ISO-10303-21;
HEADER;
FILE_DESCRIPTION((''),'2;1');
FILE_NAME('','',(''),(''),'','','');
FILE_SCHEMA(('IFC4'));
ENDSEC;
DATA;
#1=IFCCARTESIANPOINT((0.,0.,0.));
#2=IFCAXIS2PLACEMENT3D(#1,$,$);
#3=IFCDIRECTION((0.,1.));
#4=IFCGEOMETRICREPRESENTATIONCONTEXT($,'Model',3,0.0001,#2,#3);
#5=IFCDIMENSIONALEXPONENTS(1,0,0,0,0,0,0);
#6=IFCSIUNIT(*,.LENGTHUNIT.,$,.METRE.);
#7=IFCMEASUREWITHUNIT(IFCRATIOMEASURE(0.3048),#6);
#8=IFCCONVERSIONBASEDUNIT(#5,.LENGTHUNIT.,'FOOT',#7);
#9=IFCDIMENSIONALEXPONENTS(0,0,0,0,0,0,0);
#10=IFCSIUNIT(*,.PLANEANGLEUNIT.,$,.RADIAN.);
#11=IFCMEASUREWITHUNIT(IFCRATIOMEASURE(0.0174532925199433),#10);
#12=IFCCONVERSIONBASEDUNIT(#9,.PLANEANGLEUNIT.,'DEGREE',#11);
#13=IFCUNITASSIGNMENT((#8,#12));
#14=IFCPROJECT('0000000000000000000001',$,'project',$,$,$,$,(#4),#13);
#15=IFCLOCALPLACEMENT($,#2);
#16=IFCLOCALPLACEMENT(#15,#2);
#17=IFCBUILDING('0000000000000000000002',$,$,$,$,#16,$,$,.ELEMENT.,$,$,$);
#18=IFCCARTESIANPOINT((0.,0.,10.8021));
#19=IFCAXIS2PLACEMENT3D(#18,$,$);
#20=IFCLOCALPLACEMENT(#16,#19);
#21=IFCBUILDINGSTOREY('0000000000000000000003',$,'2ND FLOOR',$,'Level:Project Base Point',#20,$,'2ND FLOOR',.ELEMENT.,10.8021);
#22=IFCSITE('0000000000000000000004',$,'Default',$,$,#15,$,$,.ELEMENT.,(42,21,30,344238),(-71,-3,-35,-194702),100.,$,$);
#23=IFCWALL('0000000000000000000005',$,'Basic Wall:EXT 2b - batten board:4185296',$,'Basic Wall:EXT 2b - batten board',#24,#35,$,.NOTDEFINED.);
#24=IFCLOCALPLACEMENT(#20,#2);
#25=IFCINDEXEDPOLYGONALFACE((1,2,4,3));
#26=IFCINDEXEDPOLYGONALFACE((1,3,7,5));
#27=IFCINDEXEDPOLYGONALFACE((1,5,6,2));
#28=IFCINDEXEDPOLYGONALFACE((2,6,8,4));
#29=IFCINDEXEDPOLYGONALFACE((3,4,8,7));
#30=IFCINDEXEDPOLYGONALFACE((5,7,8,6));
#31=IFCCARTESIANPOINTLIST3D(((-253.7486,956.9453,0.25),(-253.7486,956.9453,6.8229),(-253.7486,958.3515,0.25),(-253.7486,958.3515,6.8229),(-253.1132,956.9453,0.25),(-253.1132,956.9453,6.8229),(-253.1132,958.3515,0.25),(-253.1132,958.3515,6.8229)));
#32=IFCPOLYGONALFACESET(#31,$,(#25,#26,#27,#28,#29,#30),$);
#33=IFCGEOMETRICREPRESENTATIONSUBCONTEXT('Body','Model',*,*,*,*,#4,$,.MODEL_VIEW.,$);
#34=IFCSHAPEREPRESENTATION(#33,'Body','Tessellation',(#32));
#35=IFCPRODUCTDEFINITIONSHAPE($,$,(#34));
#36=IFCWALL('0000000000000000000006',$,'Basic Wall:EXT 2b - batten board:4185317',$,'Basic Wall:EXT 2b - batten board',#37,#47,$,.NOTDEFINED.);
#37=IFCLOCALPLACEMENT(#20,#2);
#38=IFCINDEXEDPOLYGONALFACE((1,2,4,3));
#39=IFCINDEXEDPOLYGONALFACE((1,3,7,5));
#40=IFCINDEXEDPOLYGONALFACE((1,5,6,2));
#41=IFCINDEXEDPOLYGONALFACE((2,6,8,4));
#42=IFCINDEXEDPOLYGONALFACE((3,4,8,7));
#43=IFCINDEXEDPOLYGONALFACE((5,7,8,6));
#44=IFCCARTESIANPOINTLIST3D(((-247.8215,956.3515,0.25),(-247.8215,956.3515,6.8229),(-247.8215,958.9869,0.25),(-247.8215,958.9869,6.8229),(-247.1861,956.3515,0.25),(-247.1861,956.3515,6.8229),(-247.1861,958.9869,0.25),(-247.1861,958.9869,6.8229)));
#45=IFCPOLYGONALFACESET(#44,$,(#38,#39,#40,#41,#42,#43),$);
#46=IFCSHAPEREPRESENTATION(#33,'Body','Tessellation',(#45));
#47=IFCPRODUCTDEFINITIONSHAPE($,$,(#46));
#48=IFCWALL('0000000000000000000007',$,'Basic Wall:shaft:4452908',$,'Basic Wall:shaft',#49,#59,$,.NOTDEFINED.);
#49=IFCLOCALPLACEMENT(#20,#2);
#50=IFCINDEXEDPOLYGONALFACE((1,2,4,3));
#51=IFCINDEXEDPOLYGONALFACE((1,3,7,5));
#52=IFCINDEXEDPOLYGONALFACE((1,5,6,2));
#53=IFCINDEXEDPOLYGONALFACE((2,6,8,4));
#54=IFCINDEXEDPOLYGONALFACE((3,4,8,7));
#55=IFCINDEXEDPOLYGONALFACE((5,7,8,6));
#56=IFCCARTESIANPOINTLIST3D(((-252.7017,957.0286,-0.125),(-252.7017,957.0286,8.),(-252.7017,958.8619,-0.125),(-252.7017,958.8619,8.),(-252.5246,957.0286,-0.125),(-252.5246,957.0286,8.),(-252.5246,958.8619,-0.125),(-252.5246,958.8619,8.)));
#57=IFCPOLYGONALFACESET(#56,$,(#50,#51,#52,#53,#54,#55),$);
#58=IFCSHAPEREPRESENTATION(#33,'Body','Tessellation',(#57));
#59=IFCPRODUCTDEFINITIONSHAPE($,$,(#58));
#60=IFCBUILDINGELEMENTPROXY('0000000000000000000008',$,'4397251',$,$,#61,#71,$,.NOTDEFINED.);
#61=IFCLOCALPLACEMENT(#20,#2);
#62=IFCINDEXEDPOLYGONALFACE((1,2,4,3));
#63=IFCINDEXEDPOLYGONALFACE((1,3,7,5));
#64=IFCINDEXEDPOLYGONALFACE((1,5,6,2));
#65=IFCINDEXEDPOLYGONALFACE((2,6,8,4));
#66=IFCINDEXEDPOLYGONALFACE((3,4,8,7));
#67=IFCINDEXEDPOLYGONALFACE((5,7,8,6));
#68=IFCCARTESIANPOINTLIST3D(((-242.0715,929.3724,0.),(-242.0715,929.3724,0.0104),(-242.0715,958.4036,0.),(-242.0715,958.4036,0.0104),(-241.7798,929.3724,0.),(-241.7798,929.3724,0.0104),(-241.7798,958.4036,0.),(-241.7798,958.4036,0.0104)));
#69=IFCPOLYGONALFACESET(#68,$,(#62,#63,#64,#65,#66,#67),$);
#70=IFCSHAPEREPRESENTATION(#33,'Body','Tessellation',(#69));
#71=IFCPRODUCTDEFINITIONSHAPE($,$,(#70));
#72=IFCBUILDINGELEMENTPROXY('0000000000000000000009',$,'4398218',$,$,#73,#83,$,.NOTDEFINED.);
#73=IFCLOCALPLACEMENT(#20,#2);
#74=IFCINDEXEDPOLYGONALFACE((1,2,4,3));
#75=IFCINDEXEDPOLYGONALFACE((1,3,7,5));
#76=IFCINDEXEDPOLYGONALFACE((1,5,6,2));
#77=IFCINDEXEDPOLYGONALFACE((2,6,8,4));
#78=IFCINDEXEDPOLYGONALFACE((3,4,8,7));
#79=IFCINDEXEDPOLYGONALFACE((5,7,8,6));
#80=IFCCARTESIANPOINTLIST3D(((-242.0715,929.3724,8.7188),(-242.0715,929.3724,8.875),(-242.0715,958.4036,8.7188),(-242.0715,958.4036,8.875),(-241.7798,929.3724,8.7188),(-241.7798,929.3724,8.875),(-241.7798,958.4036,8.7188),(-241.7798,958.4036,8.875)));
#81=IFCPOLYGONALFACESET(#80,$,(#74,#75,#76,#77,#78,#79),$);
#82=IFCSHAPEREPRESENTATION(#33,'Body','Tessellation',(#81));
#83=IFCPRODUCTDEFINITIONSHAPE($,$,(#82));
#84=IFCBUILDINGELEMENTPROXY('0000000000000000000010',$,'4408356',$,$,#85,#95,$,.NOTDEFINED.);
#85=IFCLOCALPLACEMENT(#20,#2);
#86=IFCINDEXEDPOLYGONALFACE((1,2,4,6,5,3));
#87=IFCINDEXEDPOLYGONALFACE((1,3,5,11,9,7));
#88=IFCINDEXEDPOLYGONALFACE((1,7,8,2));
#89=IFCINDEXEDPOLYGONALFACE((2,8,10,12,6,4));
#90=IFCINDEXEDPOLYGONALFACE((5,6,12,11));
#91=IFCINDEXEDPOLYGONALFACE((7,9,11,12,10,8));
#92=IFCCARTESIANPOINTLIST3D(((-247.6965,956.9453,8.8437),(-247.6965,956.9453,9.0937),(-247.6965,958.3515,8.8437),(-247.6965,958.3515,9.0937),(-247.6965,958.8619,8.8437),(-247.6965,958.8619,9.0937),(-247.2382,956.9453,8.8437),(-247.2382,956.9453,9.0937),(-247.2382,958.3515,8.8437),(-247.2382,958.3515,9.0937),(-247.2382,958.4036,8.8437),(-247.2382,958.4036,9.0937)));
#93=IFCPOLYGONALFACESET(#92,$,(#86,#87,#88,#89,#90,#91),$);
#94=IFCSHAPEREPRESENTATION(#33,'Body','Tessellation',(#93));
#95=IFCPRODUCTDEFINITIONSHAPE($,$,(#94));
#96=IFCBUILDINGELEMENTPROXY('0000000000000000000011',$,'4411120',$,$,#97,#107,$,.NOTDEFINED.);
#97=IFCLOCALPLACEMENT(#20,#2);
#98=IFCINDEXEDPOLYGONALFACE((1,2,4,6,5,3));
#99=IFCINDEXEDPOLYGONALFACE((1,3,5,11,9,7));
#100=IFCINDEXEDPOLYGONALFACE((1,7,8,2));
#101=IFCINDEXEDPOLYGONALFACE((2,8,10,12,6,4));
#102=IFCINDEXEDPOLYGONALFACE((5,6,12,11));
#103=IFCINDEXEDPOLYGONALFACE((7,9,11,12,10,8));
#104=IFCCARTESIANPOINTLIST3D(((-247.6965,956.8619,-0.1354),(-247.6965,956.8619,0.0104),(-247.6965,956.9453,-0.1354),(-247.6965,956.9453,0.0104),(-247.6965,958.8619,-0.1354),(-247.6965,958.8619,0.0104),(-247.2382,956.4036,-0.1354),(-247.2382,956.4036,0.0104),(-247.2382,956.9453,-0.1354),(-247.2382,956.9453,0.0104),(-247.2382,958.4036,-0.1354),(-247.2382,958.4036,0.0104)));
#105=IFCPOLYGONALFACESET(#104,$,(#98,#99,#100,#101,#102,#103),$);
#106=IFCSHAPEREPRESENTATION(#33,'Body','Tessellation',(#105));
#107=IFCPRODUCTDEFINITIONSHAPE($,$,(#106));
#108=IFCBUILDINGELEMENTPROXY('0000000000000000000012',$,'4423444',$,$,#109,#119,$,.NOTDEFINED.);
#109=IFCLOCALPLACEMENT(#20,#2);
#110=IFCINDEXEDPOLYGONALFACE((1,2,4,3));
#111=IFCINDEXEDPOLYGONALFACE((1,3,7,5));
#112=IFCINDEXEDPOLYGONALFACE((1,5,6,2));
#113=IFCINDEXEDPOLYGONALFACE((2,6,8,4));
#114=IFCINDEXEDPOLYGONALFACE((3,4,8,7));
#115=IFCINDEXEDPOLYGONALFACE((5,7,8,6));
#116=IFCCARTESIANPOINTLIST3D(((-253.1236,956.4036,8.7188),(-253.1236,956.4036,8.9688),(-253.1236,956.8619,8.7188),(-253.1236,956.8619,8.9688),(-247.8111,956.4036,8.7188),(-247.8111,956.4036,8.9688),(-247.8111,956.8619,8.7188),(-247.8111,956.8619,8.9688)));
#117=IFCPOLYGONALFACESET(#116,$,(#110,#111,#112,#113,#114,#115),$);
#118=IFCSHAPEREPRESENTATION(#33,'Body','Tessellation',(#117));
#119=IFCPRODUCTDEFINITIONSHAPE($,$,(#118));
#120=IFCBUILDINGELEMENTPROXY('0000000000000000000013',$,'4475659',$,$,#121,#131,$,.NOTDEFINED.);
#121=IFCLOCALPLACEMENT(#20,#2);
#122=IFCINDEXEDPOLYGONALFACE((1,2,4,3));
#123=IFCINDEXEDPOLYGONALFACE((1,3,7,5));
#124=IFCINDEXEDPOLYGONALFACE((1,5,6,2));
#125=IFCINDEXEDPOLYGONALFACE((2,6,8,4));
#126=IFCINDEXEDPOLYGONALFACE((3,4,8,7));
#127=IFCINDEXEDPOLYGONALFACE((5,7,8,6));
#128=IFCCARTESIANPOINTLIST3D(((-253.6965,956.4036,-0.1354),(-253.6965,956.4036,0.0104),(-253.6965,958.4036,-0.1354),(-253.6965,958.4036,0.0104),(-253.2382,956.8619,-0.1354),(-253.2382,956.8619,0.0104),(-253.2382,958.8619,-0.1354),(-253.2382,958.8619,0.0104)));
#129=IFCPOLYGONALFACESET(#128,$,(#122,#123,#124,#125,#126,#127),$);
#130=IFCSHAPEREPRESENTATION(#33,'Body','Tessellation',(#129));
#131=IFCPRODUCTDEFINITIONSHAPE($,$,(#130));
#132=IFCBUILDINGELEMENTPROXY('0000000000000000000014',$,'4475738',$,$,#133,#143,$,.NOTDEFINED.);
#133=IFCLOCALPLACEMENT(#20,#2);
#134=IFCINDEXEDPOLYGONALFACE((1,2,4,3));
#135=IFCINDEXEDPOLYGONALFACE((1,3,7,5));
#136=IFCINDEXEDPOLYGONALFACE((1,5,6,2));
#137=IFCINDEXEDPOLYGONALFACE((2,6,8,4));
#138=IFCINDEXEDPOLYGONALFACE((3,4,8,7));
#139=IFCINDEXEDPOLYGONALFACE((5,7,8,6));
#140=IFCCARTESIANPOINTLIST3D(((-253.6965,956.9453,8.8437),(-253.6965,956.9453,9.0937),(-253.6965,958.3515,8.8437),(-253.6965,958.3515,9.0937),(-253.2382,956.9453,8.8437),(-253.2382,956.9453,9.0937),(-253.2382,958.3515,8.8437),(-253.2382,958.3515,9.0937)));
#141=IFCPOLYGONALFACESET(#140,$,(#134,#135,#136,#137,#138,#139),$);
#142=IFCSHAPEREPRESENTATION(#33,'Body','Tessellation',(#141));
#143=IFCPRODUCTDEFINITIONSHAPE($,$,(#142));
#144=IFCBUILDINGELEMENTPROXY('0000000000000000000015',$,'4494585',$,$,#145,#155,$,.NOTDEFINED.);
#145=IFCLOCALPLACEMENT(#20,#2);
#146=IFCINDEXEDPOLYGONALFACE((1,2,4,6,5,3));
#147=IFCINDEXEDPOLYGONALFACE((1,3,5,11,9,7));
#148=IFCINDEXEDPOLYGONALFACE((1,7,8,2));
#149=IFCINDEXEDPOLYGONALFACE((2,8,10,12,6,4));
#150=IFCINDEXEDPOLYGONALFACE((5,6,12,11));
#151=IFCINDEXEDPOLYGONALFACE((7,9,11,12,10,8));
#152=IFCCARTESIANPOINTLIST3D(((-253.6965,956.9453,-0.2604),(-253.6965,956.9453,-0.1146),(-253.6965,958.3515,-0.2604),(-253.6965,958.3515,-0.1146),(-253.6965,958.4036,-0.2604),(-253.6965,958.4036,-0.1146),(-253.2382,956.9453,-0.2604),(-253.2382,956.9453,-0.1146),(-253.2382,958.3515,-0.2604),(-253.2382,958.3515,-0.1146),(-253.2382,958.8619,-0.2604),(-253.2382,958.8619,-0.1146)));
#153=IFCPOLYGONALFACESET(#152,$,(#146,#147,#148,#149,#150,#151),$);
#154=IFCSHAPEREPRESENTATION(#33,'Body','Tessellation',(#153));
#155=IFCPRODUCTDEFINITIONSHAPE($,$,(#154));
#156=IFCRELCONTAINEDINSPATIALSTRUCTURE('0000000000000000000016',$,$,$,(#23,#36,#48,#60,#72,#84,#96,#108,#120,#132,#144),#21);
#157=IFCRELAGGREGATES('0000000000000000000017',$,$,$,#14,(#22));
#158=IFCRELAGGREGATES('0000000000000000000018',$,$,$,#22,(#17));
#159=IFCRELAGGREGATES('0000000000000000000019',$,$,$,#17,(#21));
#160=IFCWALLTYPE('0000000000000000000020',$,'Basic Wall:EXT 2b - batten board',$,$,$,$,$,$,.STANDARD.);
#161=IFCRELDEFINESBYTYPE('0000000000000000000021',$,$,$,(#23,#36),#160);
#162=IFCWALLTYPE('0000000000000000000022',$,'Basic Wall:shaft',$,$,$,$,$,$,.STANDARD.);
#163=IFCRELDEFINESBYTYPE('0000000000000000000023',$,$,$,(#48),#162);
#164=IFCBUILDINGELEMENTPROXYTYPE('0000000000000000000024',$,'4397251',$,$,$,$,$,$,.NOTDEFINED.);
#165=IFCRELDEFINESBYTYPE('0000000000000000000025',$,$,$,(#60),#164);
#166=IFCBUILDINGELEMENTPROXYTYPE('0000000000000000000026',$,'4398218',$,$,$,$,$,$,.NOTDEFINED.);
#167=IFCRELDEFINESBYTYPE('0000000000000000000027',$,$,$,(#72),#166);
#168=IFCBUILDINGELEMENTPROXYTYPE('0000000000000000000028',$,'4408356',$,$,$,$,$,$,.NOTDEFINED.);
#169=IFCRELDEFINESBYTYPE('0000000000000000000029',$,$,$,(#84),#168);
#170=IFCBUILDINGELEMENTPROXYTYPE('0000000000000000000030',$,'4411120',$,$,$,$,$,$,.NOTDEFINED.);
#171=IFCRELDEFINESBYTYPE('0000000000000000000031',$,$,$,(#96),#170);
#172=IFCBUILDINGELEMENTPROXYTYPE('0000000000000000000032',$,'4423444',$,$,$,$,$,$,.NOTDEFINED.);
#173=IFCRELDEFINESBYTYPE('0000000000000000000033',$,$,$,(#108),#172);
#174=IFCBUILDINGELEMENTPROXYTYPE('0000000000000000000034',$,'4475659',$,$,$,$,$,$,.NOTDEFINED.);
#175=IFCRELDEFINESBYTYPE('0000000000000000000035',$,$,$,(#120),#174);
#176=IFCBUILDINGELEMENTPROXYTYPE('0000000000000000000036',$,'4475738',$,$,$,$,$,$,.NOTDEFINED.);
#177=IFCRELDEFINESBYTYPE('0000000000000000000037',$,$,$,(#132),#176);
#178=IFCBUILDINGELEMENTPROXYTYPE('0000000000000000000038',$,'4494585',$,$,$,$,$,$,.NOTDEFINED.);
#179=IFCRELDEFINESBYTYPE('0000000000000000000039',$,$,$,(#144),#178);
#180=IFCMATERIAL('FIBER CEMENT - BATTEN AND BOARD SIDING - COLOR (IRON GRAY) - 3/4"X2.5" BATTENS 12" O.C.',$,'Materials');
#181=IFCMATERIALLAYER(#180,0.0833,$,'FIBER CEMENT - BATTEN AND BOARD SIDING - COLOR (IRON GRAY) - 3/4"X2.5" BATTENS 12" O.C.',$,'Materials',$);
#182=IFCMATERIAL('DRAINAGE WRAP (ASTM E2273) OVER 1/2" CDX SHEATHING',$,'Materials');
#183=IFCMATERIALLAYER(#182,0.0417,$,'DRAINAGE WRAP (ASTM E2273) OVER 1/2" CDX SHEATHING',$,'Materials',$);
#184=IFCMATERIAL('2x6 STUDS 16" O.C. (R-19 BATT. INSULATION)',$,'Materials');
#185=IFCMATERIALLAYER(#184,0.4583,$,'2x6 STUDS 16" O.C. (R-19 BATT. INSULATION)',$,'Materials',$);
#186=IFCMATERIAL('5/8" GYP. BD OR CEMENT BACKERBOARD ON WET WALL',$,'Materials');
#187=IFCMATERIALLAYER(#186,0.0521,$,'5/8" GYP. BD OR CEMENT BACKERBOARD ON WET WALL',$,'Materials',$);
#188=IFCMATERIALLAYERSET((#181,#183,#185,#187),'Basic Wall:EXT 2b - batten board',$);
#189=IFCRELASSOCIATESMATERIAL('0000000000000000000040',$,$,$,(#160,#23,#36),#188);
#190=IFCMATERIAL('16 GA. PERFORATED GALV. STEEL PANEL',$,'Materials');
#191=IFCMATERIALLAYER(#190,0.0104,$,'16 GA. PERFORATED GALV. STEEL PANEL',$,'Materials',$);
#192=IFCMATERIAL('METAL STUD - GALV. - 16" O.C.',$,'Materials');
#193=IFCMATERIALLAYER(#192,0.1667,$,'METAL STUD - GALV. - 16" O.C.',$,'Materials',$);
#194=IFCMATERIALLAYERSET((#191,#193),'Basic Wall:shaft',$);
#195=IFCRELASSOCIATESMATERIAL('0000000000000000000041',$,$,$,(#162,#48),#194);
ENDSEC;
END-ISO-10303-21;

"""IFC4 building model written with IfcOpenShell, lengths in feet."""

from ifc_helpers import new_model, entity, si_unit, converted_unit, direction, frame, frame_2d, origin, origin_2d_with_axis, place, context, subcontext, project, spatial, polyline, rectangle, outline, extrude, material, layer, layer_set, layer_usage, type_object, element, save


model = new_model("IFC4")

# Units and contexts
model_context = context("Model", 3, precision=0.0001, world=origin(), true_north=direction((0.0, 1.0)))
body_context = subcontext(model_context, "Body", "Model", "MODEL_VIEW")
ifc_project = project(units=[converted_unit("LENGTHUNIT", "FOOT", entity("IfcRatioMeasure", 0.3048), si_unit("LENGTHUNIT", "METRE"), dimensions=[1, 0, 0, 0, 0, 0, 0]), converted_unit("PLANEANGLEUNIT", "DEGREE", entity("IfcRatioMeasure", 0.0174532925199433), si_unit("PLANEANGLEUNIT", "RADIAN"), dimensions=[0, 0, 0, 0, 0, 0, 0])], contexts=[model_context])

# Site, building, storey
site_placement = place(None, origin())
site = spatial("IfcSite", under=ifc_project, at=site_placement, Name="Default", CompositionType="ELEMENT", RefLatitude=(42, 21, 30, 344238), RefLongitude=(-71, -3, -35, -194702), RefElevation=100.0)
building_placement = place(site_placement, origin())
building = spatial("IfcBuilding", under=site, at=building_placement, CompositionType="ELEMENT")
storey_placement = place(building_placement, frame((0.0, 0.0, 10.8021)))
storey = spatial("IfcBuildingStorey", under=building, at=storey_placement, Name="2ND FLOOR", ObjectType="Level:Project Base Point", LongName="2ND FLOOR", CompositionType="ELEMENT", Elevation=10.8021)

# Walls
ifc_material_1 = material(Name="DRAINAGE WRAP (ASTM E2273) OVER 1/2\" CDX SHEATHING", Category="Materials")
ifc_material_2 = material(Name="2x6 STUDS 16\" O.C. (R-19 BATT. INSULATION)", Category="Materials")
ifc_material_3 = material(Name="5/8\" GYP. BD OR CEMENT BACKERBOARD ON WET WALL", Category="Materials")
ifc_material_4 = material(Name="FIBER CEMENT - BATTEN AND BOARD SIDING - COLOR (IRON GRAY) - 3/4\"X2.5\" BATTENS 12\" O.C.", Category="Materials")
ifc_layer_1 = layer(ifc_material_4, 0.0833, Name="FIBER CEMENT - BATTEN AND BOARD SIDING - COLOR (IRON GRAY) - 3/4\"X2.5\" BATTENS 12\" O.C.", Category="Materials")
ifc_layer_2 = layer(ifc_material_1, 0.0417, Name="DRAINAGE WRAP (ASTM E2273) OVER 1/2\" CDX SHEATHING", Category="Materials")
ifc_layer_3 = layer(ifc_material_2, 0.4583, Name="2x6 STUDS 16\" O.C. (R-19 BATT. INSULATION)", Category="Materials")
ifc_layer_4 = layer(ifc_material_3, 0.0521, Name="5/8\" GYP. BD OR CEMENT BACKERBOARD ON WET WALL", Category="Materials")
ifc_layer_set_1 = layer_set([ifc_layer_1, ifc_layer_2, ifc_layer_3, ifc_layer_4], Name="Basic Wall:EXT 2b - batten board")
ifc_layer_usage_1 = layer_usage(ifc_layer_set_1, "AXIS2", "POSITIVE", -0.3177)
wall_type_1 = type_object("IfcWallType", Name="Basic Wall:EXT 2b - batten board", PredefinedType="STANDARD", material=ifc_layer_set_1)
wall_1_placement = place(storey_placement, frame((-253.4309, 956.9453, 0.25), z_axis=(0.0, 0.0, 1.0), x_axis=(0.0, 1.0, 0.0)))
element("IfcWall", 1, at=wall_1_placement, inside=storey, type_object=wall_type_1, material=ifc_layer_usage_1, Name="Basic Wall:EXT 2b - batten board:4185296", ObjectType="Basic Wall:EXT 2b - batten board", PredefinedType="NOTDEFINED", context=body_context, shape_type="SweptSolid", body=[
    extrude(rectangle(XDim=1.4062, YDim=0.6354, at=frame_2d((0.7031, 0.0), x_axis=(-1.0, 0.0))), origin(), (0.0, 0.0, 1.0), 6.5729),
])
ifc_layer_usage_2 = layer_usage(ifc_layer_set_1, "AXIS2", "NEGATIVE", 0.3177)
wall_2_placement = place(storey_placement, frame((-247.5038, 956.3515, 0.25), z_axis=(0.0, 0.0, 1.0), x_axis=(0.0, 1.0, 0.0)))
element("IfcWall", 2, at=wall_2_placement, inside=storey, type_object=wall_type_1, material=ifc_layer_usage_2, Name="Basic Wall:EXT 2b - batten board:4185317", ObjectType="Basic Wall:EXT 2b - batten board", PredefinedType="NOTDEFINED", context=body_context, shape_type="SweptSolid", body=[
    extrude(rectangle(XDim=2.6354, YDim=0.6354, at=frame_2d((1.3177, 0.0), x_axis=(-1.0, 0.0))), origin(), (0.0, 0.0, 1.0), 6.5729),
])
ifc_material_5 = material(Name="16 GA. PERFORATED GALV. STEEL PANEL", Category="Materials")
ifc_layer_5 = layer(ifc_material_5, 0.0104, Name="16 GA. PERFORATED GALV. STEEL PANEL", Category="Materials")
ifc_material_6 = material(Name="METAL STUD - GALV. - 16\" O.C.", Category="Materials")
ifc_layer_6 = layer(ifc_material_6, 0.1667, Name="METAL STUD - GALV. - 16\" O.C.", Category="Materials")
ifc_layer_set_2 = layer_set([ifc_layer_5, ifc_layer_6], Name="Basic Wall:shaft")
ifc_layer_usage_3 = layer_usage(ifc_layer_set_2, "AXIS2", "POSITIVE", -0.0885)
wall_type_2 = type_object("IfcWallType", Name="Basic Wall:shaft", PredefinedType="STANDARD", material=ifc_layer_set_2)
wall_3_placement = place(storey_placement, frame((-252.6132, 957.0286, -0.125), z_axis=(0.0, 0.0, 1.0), x_axis=(0.0, 1.0, 0.0)))
element("IfcWall", 3, at=wall_3_placement, inside=storey, type_object=wall_type_2, material=ifc_layer_usage_3, Name="Basic Wall:shaft:4452908", ObjectType="Basic Wall:shaft", PredefinedType="NOTDEFINED", context=body_context, shape_type="SweptSolid", body=[
    extrude(rectangle(XDim=1.8333, YDim=0.1771, at=frame_2d((0.9167, 0.0), x_axis=(-1.0, 0.0))), origin(), (0.0, 0.0, 1.0), 8.125),
])

# Building element proxies
building_element_proxy_type_1 = type_object("IfcBuildingElementProxyType", Name="4397251", PredefinedType="NOTDEFINED")
proxy_1_placement = place(storey_placement, frame((-242.0715, 929.3724, 0.0)))
element("IfcBuildingElementProxy", 4, at=proxy_1_placement, inside=storey, type_object=building_element_proxy_type_1, Name="4397251", PredefinedType="NOTDEFINED", context=body_context, shape_type="SweptSolid", body=[
    extrude(rectangle(XDim=29.0313, YDim=0.2917, at=origin_2d_with_axis()), frame((0.1458, 14.5156, 0.0), z_axis=(0.0, 0.0, 1.0), x_axis=(0.0, 1.0, 0.0)), (0.0, 0.0, 1.0), 0.0104),
])
building_element_proxy_type_2 = type_object("IfcBuildingElementProxyType", Name="4398218", PredefinedType="NOTDEFINED")
proxy_2_placement = place(storey_placement, frame((-242.0715, 929.3724, 8.7188)))
element("IfcBuildingElementProxy", 5, at=proxy_2_placement, inside=storey, type_object=building_element_proxy_type_2, Name="4398218", PredefinedType="NOTDEFINED", context=body_context, shape_type="SweptSolid", body=[
    extrude(rectangle(XDim=29.0313, YDim=0.2917, at=origin_2d_with_axis()), frame((0.1458, 14.5156, 0.0), z_axis=(0.0, 0.0, 1.0), x_axis=(0.0, 1.0, 0.0)), (0.0, 0.0, 1.0), 0.1562),
])
building_element_proxy_type_3 = type_object("IfcBuildingElementProxyType", Name="4408356", PredefinedType="NOTDEFINED")
proxy_3_placement = place(storey_placement, frame((-247.6965, 956.9453, 8.8437)))
element("IfcBuildingElementProxy", 6, at=proxy_3_placement, inside=storey, type_object=building_element_proxy_type_3, Name="4408356", PredefinedType="NOTDEFINED", context=body_context, shape_type="SweptSolid", body=[
    extrude(outline(polyline([(-1.0313, -0.2292), (0.375, -0.2292), (0.4271, -0.2292), (0.8854, 0.2292), (0.375, 0.2292), (-1.0313, 0.2292), (-1.0313, -0.2292)])), frame((0.2292, 1.0313, 0.0), z_axis=(0.0, 0.0, 1.0), x_axis=(0.0, 1.0, 0.0)), (0.0, 0.0, 1.0), 0.25),
])
building_element_proxy_type_4 = type_object("IfcBuildingElementProxyType", Name="4411120", PredefinedType="NOTDEFINED")
proxy_4_placement = place(storey_placement, frame((-247.6965, 956.4036, -0.1354)))
element("IfcBuildingElementProxy", 7, at=proxy_4_placement, inside=storey, type_object=building_element_proxy_type_4, Name="4411120", PredefinedType="NOTDEFINED", context=body_context, shape_type="SweptSolid", body=[
    extrude(outline(polyline([(-1.0, -0.2292), (-0.4583, -0.2292), (1.0, -0.2292), (1.4583, 0.2292), (-0.4583, 0.2292), (-0.5417, 0.2292), (-1.0, -0.2292)])), frame((0.2292, 1.0, 0.0), z_axis=(0.0, 0.0, 1.0), x_axis=(0.0, 1.0, 0.0)), (0.0, 0.0, 1.0), 0.1458),
])
building_element_proxy_type_5 = type_object("IfcBuildingElementProxyType", Name="4423444", PredefinedType="NOTDEFINED")
proxy_5_placement = place(storey_placement, frame((-253.1236, 956.4036, 8.7188)))
element("IfcBuildingElementProxy", 8, at=proxy_5_placement, inside=storey, type_object=building_element_proxy_type_5, Name="4423444", PredefinedType="NOTDEFINED", context=body_context, shape_type="SweptSolid", body=[
    extrude(rectangle(XDim=5.3125, YDim=0.4583, at=frame_2d((0.0, 0.0), x_axis=(1.0, 0.0))), frame((2.6563, 0.2292, 0.0)), (0.0, 0.0, 1.0), 0.25),
])
building_element_proxy_type_6 = type_object("IfcBuildingElementProxyType", Name="4475659", PredefinedType="NOTDEFINED")
proxy_6_placement = place(storey_placement, frame((-253.6965, 956.4036, -0.1354)))
element("IfcBuildingElementProxy", 9, at=proxy_6_placement, inside=storey, type_object=building_element_proxy_type_6, Name="4475659", PredefinedType="NOTDEFINED", context=body_context, shape_type="SweptSolid", body=[
    extrude(outline(polyline([(-0.7708, -0.2292), (1.2292, -0.2292), (0.7708, 0.2292), (-1.2292, 0.2292), (-0.7708, -0.2292)])), frame((0.2292, 1.2292, 0.0), z_axis=(0.0, 0.0, 1.0), x_axis=(0.0, 1.0, 0.0)), (0.0, 0.0, 1.0), 0.1458),
])
building_element_proxy_type_7 = type_object("IfcBuildingElementProxyType", Name="4475738", PredefinedType="NOTDEFINED")
proxy_7_placement = place(storey_placement, frame((-253.6965, 956.9453, 8.8437)))
element("IfcBuildingElementProxy", 10, at=proxy_7_placement, inside=storey, type_object=building_element_proxy_type_7, Name="4475738", PredefinedType="NOTDEFINED", context=body_context, shape_type="SweptSolid", body=[
    extrude(rectangle(XDim=1.4062, YDim=0.4583, at=frame_2d((0.0, 0.0), x_axis=(1.0, 0.0))), frame((0.2292, 0.7031, 0.0), z_axis=(0.0, 0.0, 1.0), x_axis=(0.0, 1.0, 0.0)), (0.0, 0.0, 1.0), 0.25),
])
building_element_proxy_type_8 = type_object("IfcBuildingElementProxyType", Name="4494585", PredefinedType="NOTDEFINED")
proxy_8_placement = place(storey_placement, frame((-253.6965, 956.9453, -0.2604)))
element("IfcBuildingElementProxy", 11, at=proxy_8_placement, inside=storey, type_object=building_element_proxy_type_8, Name="4494585", PredefinedType="NOTDEFINED", context=body_context, shape_type="SweptSolid", body=[
    extrude(outline(polyline([(-1.0312, -0.2292), (0.375, -0.2292), (0.8854, -0.2292), (0.4271, 0.2292), (0.375, 0.2292), (-1.0312, 0.2292), (-1.0312, -0.2292)])), frame((0.2292, 1.0312, 0.0), z_axis=(0.0, 0.0, 1.0), x_axis=(0.0, 1.0, 0.0)), (0.0, 0.0, 1.0), 0.1458),
])

save(model, "model.ifc")
